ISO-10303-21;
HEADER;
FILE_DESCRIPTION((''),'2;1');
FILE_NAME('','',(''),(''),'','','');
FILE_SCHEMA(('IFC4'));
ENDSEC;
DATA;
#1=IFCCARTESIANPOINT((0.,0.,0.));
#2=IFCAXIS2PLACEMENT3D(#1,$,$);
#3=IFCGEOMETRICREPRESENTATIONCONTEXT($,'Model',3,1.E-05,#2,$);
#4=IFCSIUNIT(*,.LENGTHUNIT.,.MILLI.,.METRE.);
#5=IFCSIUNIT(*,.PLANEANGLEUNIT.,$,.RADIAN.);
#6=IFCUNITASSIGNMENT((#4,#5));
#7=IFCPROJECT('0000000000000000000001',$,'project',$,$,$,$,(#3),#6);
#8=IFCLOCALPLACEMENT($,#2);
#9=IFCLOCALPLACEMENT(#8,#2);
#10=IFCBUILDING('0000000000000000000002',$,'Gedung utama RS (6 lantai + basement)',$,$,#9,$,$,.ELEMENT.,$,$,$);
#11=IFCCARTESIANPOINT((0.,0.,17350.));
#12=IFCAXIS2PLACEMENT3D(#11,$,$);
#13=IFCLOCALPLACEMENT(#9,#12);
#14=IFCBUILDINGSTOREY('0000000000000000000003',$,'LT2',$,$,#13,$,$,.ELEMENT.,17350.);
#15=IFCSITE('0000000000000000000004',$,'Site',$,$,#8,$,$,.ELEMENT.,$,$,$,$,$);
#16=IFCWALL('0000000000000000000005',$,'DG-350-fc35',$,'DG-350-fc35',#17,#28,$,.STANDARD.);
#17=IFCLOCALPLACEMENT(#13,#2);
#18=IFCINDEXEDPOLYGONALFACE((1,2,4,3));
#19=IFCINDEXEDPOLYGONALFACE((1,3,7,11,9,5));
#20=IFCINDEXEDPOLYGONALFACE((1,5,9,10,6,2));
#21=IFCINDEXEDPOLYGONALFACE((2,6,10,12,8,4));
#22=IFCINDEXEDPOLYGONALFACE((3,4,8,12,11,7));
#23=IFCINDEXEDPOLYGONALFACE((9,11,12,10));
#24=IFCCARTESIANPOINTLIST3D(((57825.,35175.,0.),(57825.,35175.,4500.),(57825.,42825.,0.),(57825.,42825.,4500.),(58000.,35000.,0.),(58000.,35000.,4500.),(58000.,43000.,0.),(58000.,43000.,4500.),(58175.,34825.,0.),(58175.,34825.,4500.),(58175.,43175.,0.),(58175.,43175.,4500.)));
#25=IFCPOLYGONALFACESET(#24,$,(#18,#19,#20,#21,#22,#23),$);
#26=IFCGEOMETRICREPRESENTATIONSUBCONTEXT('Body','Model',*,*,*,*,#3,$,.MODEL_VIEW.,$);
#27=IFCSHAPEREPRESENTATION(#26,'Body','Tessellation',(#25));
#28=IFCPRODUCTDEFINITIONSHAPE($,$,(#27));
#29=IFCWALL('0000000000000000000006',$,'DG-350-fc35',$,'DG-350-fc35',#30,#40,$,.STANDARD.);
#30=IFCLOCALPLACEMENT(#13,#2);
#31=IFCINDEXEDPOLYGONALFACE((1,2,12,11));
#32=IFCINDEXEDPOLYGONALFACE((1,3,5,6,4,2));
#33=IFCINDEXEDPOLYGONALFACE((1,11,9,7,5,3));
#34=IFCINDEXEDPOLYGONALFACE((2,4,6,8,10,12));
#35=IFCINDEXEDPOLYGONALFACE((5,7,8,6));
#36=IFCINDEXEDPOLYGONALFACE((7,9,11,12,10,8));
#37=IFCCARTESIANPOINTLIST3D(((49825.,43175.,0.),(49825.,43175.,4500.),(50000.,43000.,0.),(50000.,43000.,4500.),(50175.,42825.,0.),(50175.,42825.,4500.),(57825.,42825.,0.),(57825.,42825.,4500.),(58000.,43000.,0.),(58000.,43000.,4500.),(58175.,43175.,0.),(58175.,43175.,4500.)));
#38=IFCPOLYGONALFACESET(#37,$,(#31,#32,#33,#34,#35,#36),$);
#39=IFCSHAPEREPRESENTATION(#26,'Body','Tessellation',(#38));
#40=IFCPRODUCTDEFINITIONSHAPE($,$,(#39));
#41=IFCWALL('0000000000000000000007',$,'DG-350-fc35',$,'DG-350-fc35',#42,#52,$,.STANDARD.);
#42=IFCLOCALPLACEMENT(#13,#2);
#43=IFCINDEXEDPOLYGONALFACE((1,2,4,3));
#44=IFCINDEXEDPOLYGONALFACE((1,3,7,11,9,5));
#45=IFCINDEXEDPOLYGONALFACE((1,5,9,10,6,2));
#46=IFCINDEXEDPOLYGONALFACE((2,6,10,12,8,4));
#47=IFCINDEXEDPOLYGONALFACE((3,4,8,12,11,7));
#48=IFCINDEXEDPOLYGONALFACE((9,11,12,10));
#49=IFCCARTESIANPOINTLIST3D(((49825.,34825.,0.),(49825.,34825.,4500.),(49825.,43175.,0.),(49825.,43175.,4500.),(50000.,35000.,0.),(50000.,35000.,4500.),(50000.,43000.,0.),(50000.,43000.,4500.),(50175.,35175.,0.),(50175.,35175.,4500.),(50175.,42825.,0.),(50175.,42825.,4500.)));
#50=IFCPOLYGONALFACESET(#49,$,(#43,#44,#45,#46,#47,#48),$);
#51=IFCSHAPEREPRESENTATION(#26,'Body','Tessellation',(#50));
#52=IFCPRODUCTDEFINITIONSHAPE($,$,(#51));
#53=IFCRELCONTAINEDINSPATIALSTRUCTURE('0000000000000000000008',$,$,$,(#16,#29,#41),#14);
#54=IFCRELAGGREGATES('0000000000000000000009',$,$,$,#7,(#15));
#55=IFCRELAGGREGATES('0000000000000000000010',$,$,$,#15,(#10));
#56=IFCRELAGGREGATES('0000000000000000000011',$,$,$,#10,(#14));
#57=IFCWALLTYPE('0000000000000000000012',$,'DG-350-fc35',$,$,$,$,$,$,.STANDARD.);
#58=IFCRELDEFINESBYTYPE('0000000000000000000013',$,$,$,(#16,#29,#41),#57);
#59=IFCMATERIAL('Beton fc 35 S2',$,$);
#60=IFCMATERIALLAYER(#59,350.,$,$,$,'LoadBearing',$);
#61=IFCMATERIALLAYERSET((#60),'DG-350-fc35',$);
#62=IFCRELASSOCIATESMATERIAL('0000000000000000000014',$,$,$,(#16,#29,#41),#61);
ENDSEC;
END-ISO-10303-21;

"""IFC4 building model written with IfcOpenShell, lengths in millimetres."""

from ifc_helpers import new_model, si_unit, frame, origin, place, context, subcontext, project, spatial, polyline, outline, extrude, material, layer, layer_set, layer_usage, type_object, element, save


model = new_model("IFC4")

# Units and contexts
model_context = context("Model", 3, precision=1e-05, world=origin())
body_context = subcontext(model_context, "Body", "Model", "MODEL_VIEW")
ifc_project = project(units=[si_unit("LENGTHUNIT", "METRE", prefix="MILLI"), si_unit("PLANEANGLEUNIT", "RADIAN")], contexts=[model_context])

# Site, building, storey
site_placement = place(None, origin())
site = spatial("IfcSite", under=ifc_project, at=site_placement, Name="Site", CompositionType="ELEMENT")
building_placement = place(site_placement, origin())
building = spatial("IfcBuilding", under=site, at=building_placement, Name="Gedung utama RS (6 lantai + basement)", CompositionType="ELEMENT")
storey_placement = place(building_placement, frame((0.0, 0.0, 17350.0)))
storey = spatial("IfcBuildingStorey", under=building, at=storey_placement, Name="LT2", CompositionType="ELEMENT", Elevation=17350.0)

# Shared definitions
ifc_material_1 = material(Name="Beton fc 35 S2")
ifc_layer = layer(ifc_material_1, 350.0, Category="LoadBearing")
ifc_layer_set = layer_set([ifc_layer], Name="DG-350-fc35")
ifc_layer_usage = layer_usage(ifc_layer_set, "AXIS2", "NEGATIVE", 175.0)
wall_type = type_object("IfcWallType", Name="DG-350-fc35", PredefinedType="STANDARD")

# Walls
for number, where, z_axis, x_axis, name in (
    (1, (58000.0, 35000.0, 0.0), (0.0, 0.0, 1.0), (0.0, 1.0, 0.0), "DG-350-fc35"),
    (2, (58000.0, 43000.0, 0.0), (0.0, 0.0, 1.0), (-1.0, 0.0, 0.0), "DG-350-fc35"),
    (3, (50000.0, 43000.0, 0.0), (0.0, 0.0, 1.0), (0.0, -1.0, 0.0), "DG-350-fc35"),
):
    element("IfcWall", number, at=place(storey_placement, frame(where, z_axis=z_axis, x_axis=x_axis)), inside=storey, type_object=wall_type, material=ifc_layer_usage, Name=name, ObjectType="DG-350-fc35", PredefinedType="STANDARD", context=body_context, shape_type="SweptSolid", body=[
        extrude(outline(polyline([(-175.0, -175.0), (0.0, 0.0), (175.0, 175.0), (7825.0, 175.0), (8000.0, 0.0), (8175.0, -175.0), (-175.0, -175.0)])), origin(), (0.0, 0.0, 1.0), 4500.0),
    ])

save(model, "model.ifc")
